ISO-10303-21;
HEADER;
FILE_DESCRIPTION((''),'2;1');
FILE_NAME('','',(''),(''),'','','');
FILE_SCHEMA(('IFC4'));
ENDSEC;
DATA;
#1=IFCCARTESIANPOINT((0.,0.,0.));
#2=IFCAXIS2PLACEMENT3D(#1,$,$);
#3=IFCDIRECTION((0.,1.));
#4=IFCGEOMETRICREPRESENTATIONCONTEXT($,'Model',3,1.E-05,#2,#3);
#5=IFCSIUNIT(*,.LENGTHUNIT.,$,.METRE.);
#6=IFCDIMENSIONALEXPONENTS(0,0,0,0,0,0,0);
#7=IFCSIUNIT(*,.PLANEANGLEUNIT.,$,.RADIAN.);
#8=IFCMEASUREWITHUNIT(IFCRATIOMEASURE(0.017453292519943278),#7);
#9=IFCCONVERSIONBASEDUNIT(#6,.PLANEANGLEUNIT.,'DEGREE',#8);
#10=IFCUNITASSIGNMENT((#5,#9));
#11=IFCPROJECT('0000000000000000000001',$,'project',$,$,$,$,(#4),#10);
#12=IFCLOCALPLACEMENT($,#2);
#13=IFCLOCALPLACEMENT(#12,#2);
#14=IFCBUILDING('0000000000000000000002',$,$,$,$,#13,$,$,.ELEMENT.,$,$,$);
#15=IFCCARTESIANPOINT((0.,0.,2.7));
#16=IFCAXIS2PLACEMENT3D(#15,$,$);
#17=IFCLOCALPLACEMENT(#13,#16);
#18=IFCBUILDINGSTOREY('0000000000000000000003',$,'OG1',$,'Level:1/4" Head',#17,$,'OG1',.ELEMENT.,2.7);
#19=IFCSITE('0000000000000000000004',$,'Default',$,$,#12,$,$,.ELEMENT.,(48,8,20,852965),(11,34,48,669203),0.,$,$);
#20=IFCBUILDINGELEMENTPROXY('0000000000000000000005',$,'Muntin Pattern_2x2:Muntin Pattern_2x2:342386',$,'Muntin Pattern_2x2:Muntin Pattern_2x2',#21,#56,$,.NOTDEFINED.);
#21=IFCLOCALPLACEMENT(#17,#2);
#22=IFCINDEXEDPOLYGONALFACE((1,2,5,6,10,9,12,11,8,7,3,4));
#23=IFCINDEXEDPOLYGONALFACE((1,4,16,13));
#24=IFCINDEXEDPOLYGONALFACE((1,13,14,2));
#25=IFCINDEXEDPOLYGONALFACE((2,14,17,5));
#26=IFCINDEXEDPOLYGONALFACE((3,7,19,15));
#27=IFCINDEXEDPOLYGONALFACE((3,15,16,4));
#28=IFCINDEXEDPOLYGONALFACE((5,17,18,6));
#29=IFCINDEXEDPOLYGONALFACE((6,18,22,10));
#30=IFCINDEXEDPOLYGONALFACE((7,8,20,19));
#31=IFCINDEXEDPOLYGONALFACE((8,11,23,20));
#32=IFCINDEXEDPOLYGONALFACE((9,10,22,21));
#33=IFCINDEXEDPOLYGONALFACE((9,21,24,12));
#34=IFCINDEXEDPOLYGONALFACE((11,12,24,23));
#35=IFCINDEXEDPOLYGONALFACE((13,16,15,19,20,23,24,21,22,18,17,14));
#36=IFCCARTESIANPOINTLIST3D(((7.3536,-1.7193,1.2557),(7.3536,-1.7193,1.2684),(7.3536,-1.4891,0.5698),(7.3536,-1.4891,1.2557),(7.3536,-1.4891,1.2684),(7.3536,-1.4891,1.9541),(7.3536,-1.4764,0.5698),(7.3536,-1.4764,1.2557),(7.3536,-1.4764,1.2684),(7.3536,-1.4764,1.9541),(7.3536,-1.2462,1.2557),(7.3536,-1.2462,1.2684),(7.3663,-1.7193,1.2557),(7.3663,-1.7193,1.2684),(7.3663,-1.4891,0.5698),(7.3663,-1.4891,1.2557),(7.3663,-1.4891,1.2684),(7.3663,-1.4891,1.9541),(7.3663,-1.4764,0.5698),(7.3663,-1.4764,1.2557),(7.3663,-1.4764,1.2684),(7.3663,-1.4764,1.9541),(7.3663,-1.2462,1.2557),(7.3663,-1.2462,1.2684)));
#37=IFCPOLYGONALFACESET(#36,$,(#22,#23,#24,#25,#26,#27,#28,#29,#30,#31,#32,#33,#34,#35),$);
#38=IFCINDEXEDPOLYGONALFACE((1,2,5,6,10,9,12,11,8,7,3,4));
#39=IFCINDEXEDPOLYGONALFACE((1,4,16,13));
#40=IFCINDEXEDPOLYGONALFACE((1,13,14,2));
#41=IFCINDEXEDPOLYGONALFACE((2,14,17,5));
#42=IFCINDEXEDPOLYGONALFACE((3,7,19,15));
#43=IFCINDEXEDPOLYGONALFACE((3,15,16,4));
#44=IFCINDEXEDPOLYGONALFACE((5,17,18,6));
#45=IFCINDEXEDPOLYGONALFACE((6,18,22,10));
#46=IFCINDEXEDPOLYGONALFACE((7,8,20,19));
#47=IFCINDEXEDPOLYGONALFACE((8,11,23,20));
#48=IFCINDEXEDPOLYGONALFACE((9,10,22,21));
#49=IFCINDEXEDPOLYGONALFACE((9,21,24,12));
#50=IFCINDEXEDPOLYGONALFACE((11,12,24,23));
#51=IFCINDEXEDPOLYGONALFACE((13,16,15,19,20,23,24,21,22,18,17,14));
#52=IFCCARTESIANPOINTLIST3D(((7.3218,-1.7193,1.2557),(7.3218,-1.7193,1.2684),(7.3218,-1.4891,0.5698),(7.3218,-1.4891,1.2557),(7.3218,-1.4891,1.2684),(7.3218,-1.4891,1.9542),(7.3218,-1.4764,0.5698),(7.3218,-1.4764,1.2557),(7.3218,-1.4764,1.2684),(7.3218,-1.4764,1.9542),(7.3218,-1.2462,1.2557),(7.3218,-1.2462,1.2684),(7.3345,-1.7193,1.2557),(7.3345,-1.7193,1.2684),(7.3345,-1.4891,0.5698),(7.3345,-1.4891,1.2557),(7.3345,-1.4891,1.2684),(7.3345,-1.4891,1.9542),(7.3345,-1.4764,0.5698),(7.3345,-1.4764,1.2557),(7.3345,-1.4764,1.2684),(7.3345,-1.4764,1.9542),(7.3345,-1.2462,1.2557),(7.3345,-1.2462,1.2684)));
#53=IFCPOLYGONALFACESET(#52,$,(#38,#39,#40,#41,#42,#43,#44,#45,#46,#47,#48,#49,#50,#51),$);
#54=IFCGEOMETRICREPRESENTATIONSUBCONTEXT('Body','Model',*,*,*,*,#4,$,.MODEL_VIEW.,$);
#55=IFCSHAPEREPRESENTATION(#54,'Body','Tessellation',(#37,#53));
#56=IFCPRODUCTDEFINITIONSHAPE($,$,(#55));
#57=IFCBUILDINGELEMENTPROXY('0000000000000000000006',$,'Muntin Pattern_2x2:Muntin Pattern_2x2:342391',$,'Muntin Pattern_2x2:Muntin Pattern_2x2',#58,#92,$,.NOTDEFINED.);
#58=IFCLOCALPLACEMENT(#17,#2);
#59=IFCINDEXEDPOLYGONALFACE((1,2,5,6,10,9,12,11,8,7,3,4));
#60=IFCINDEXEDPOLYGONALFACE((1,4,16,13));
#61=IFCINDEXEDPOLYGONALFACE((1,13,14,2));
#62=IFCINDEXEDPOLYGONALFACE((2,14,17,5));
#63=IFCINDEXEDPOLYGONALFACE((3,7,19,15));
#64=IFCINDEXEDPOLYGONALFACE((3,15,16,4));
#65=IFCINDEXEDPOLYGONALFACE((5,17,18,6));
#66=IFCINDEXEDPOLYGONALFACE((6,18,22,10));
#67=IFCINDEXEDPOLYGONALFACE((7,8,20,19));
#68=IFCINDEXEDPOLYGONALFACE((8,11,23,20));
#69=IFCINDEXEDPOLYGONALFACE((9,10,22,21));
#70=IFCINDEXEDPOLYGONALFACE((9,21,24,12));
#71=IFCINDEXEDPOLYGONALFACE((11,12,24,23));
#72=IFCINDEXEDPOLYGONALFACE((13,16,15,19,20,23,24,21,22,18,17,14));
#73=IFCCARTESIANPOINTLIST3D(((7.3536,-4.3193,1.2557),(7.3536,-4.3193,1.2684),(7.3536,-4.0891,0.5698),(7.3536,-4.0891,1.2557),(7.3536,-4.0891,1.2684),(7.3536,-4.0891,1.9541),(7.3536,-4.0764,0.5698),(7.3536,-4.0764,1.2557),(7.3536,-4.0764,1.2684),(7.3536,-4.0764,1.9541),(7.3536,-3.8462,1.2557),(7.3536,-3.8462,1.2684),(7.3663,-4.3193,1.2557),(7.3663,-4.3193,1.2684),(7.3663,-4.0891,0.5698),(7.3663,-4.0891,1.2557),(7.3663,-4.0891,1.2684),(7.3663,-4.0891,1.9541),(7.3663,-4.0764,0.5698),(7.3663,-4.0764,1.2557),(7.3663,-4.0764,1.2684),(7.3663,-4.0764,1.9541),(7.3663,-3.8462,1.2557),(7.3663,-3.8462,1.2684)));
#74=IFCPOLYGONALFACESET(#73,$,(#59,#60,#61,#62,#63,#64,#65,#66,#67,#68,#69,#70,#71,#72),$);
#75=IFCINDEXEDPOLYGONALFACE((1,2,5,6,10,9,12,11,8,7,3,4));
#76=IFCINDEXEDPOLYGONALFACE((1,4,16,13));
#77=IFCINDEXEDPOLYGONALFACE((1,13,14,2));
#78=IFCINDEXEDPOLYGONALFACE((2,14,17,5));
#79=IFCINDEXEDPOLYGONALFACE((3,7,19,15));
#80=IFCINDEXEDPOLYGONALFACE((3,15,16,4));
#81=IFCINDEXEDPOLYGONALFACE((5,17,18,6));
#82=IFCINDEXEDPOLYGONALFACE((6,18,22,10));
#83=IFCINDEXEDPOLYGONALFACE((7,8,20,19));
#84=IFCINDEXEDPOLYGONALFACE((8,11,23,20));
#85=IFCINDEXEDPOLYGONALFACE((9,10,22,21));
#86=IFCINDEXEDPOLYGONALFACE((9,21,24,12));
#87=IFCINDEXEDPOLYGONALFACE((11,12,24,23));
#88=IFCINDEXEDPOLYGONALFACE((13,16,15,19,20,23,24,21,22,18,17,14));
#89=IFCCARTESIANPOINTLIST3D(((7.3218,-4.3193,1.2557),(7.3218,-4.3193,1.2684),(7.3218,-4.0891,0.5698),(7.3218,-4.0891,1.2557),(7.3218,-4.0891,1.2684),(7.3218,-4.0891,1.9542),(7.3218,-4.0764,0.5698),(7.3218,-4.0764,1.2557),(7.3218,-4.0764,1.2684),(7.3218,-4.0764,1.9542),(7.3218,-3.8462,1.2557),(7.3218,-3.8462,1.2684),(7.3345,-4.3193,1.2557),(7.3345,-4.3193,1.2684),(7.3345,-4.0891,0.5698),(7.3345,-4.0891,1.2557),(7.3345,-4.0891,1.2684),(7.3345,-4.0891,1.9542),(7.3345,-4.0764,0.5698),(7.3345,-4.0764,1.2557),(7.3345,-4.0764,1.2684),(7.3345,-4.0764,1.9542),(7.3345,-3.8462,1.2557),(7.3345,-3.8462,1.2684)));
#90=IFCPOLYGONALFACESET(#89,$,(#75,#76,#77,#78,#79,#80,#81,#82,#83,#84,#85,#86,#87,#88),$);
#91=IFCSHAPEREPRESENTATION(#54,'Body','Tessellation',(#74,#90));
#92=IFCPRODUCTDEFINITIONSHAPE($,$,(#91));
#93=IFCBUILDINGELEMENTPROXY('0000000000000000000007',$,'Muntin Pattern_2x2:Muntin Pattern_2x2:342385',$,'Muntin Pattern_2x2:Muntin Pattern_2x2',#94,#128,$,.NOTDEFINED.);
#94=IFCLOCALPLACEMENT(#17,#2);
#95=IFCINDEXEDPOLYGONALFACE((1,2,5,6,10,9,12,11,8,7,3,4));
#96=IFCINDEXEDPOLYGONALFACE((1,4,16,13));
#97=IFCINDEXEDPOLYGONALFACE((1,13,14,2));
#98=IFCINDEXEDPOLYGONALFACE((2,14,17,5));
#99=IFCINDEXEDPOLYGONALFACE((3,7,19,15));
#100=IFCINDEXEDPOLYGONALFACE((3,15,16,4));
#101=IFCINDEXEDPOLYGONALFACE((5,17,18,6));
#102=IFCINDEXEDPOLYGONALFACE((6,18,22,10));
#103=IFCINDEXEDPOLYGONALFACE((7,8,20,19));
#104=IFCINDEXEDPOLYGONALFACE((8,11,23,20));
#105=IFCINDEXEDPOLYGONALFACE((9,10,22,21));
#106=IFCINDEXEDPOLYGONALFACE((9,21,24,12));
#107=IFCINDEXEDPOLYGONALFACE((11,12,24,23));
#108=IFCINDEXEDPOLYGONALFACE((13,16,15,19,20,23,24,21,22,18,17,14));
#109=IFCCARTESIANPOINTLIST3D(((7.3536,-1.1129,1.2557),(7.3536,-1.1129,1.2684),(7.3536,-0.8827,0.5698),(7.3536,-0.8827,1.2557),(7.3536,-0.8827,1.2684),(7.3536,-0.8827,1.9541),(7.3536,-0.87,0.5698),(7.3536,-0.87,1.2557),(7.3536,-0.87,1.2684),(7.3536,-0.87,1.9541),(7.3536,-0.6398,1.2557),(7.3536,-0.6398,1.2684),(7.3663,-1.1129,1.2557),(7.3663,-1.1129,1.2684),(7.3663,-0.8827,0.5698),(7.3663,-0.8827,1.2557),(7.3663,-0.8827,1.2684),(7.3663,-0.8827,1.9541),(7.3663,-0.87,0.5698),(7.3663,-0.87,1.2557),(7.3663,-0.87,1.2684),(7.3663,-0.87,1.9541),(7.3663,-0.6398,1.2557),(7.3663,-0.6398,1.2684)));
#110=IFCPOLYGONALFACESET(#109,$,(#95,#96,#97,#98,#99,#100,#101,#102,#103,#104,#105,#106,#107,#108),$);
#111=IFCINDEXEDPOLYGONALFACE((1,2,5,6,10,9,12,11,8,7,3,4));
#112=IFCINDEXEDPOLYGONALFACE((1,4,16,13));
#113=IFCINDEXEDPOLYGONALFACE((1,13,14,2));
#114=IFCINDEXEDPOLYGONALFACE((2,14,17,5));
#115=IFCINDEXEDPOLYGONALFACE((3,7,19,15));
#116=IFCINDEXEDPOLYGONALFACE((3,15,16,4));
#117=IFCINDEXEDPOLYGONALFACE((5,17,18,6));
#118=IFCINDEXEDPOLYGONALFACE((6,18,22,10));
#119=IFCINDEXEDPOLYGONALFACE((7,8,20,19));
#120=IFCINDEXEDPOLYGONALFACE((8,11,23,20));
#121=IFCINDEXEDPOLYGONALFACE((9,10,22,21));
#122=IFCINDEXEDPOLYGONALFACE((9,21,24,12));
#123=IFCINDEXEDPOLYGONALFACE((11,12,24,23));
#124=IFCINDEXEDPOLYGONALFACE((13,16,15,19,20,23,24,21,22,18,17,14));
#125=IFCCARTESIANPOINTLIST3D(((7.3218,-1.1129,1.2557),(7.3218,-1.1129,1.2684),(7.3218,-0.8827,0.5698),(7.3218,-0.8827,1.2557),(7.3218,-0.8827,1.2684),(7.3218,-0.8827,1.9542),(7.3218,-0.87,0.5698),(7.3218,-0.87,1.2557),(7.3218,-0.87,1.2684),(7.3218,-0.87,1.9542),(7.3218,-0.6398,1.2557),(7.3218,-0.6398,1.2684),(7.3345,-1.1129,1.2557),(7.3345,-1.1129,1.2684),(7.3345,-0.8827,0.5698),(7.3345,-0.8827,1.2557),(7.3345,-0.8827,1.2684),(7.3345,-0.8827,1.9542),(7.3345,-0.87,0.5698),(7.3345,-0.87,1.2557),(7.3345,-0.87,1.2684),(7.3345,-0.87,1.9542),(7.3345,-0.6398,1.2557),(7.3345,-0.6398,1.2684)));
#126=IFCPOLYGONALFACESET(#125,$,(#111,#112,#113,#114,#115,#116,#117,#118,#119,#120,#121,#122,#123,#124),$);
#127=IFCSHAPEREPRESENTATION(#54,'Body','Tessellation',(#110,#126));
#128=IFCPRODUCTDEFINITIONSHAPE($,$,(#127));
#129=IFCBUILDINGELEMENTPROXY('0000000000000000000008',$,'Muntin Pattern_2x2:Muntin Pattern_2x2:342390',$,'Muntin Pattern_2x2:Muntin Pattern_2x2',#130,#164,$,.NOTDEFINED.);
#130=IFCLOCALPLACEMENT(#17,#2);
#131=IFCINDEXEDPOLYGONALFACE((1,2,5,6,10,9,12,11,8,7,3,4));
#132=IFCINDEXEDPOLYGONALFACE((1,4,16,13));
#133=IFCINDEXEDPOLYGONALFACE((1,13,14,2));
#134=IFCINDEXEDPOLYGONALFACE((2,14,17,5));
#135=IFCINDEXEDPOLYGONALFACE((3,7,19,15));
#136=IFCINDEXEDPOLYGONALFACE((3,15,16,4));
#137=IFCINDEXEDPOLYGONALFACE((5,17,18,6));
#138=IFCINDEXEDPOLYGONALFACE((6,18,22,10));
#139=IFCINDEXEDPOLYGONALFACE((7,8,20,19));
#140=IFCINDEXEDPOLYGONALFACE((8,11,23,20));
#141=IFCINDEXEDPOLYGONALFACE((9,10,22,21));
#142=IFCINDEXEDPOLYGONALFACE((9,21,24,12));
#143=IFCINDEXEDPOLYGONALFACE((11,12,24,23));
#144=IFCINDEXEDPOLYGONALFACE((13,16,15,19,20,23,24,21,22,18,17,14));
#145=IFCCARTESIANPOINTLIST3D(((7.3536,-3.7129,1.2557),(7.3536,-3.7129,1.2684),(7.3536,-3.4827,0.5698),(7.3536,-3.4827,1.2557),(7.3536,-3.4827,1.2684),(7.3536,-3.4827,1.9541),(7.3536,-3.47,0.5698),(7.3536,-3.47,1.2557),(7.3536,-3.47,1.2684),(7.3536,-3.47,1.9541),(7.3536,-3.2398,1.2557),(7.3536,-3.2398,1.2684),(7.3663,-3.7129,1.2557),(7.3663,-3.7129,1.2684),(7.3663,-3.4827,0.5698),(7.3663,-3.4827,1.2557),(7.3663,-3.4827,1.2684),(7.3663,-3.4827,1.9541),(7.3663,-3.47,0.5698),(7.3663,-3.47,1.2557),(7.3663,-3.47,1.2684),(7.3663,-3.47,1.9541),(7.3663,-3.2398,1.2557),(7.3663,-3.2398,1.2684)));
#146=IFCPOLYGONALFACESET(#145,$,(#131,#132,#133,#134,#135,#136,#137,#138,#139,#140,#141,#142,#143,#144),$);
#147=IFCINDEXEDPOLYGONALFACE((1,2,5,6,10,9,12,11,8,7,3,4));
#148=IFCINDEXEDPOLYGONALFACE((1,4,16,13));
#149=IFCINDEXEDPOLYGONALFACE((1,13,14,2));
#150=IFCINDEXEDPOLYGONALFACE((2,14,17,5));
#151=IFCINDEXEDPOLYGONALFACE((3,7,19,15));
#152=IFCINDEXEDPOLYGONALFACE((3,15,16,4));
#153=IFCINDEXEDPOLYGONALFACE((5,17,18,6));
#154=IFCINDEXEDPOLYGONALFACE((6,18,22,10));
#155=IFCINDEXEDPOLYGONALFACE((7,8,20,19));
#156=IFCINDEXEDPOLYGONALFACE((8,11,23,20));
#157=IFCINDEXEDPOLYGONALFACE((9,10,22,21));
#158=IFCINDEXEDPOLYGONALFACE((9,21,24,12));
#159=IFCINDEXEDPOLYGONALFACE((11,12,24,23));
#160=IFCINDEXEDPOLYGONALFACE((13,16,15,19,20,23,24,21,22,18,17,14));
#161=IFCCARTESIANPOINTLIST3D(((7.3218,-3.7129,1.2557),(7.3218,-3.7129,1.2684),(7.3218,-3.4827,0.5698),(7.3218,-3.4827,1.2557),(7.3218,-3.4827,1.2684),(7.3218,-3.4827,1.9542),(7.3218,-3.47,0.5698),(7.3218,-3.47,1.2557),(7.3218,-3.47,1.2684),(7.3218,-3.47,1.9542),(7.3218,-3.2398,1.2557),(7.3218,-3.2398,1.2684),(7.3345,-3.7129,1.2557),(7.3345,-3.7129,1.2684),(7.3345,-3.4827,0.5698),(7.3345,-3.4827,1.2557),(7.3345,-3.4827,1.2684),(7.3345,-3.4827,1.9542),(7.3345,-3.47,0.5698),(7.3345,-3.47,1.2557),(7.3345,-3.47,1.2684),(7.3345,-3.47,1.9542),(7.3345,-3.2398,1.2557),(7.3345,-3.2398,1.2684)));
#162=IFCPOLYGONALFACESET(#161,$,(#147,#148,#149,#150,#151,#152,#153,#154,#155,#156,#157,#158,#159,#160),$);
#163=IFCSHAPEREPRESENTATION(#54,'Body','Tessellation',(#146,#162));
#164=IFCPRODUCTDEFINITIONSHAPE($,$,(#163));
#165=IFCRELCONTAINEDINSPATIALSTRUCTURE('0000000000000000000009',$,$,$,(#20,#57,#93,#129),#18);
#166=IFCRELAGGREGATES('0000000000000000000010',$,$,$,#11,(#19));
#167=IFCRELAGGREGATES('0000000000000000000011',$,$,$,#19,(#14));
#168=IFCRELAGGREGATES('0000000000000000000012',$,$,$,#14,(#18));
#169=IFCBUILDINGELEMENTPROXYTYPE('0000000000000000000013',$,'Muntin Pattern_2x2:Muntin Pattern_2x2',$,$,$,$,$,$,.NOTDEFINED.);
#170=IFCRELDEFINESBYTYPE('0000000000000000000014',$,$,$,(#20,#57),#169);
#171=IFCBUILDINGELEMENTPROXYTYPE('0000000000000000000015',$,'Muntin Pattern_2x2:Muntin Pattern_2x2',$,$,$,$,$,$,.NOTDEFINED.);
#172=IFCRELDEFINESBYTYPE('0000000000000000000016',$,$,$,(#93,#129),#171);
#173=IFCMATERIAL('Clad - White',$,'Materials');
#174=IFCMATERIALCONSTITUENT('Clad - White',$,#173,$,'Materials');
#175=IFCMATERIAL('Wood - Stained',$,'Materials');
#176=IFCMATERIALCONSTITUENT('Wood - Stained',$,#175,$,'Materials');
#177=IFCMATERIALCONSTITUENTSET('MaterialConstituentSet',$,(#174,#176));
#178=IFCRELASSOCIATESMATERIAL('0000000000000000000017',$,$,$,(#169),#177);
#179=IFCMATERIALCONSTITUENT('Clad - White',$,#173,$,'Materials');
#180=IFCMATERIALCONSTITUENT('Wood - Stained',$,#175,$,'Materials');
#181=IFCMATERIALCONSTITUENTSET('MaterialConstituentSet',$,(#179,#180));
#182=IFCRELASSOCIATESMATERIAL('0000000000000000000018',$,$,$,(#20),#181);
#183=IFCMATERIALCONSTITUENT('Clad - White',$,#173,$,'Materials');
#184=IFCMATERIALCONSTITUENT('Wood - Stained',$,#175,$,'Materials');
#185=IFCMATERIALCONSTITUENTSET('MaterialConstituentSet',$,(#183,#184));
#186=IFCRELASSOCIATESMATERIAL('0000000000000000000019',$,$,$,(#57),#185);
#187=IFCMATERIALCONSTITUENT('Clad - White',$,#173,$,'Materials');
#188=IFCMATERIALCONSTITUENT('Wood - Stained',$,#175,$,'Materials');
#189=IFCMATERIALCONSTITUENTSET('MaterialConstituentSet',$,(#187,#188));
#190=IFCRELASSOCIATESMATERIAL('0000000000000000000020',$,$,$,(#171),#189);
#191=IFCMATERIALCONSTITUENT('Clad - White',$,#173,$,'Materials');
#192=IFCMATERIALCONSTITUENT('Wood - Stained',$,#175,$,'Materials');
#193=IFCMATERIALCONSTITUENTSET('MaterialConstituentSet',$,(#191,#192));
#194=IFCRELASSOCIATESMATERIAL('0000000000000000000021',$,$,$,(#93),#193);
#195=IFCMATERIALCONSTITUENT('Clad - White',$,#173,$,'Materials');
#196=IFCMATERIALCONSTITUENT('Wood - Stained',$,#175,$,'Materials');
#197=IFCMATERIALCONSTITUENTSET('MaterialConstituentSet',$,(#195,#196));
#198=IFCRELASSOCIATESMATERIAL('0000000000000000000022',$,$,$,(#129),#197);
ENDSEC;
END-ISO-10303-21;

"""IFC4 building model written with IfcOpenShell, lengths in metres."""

from ifc_helpers import new_model, entity, si_unit, converted_unit, direction, frame, origin, place, context, subcontext, project, spatial, indexed_curve, outline, extrude, source, transform, mapped, material, constituent, constituent_set, type_object, type_shapes, element, save


model = new_model("IFC4")

# Units and contexts
model_context = context("Model", 3, precision=1e-05, world=origin(), true_north=direction((0.0, 1.0)))
body_context = subcontext(model_context, "Body", "Model", "MODEL_VIEW")
ifc_project = project(units=[si_unit("LENGTHUNIT", "METRE"), converted_unit("PLANEANGLEUNIT", "DEGREE", entity("IfcRatioMeasure", 0.017453292519943278), si_unit("PLANEANGLEUNIT", "RADIAN"), dimensions=[0, 0, 0, 0, 0, 0, 0])], contexts=[model_context])

# Site, building, storey
site_placement = place(None, origin())
site = spatial("IfcSite", under=ifc_project, at=site_placement, Name="Default", CompositionType="ELEMENT", RefLatitude=(48, 8, 20, 852965), RefLongitude=(11, 34, 48, 669203), RefElevation=0.0)
building_placement = place(site_placement, origin())
building = spatial("IfcBuilding", under=site, at=building_placement, CompositionType="ELEMENT")
storey_placement = place(building_placement, frame((0.0, 0.0, 2.7)))
storey = spatial("IfcBuildingStorey", under=building, at=storey_placement, Name="OG1", ObjectType="Level:1/4\" Head", LongName="OG1", CompositionType="ELEMENT", Elevation=2.7)

# Building element proxies
ifc_material_1 = material(Name="Clad - White", Category="Materials")
ifc_constituent_1 = constituent(ifc_material_1, Name="Clad - White", Category="Materials")
ifc_material_2 = material(Name="Wood - Stained", Category="Materials")
ifc_constituent_2 = constituent(ifc_material_2, Name="Wood - Stained", Category="Materials")
ifc_constituent_set_1 = constituent_set(constituents=[ifc_constituent_1, ifc_constituent_2], Name="MaterialConstituentSet")
ifc_constituent_3 = constituent(ifc_material_1, Name="Clad - White", Category="Materials")
ifc_constituent_4 = constituent(ifc_material_2, Name="Wood - Stained", Category="Materials")
ifc_constituent_set_2 = constituent_set(constituents=[ifc_constituent_3, ifc_constituent_4], Name="MaterialConstituentSet")
building_element_proxy_type_1 = type_object("IfcBuildingElementProxyType", Name="Muntin Pattern_2x2:Muntin Pattern_2x2", PredefinedType="NOTDEFINED", material=ifc_constituent_set_2)
shared_shape_1 = source(origin(), body_context, "Body", "SweptSolid", [
    extrude(outline(indexed_curve([(0.0064, -0.0064), (0.6921, -0.0064), (0.6921, 0.0063), (0.0064, 0.0063), (0.0064, 0.2365), (-0.0063, 0.2365), (-0.0063, 0.0063), (-0.6922, 0.0063), (-0.6922, -0.0064), (-0.0063, -0.0064), (-0.0063, -0.2365), (0.0064, -0.2365), (0.0064, -0.0064)], self_intersect=False)), frame((0.0, -0.0222, 0.6921), z_axis=(0.0, 1.0, 0.0), x_axis=(0.0, 0.0, 1.0)), (0.0, 0.0, 1.0), 0.0127),
    extrude(outline(indexed_curve([(0.0064, -0.0064), (0.6922, -0.0064), (0.6922, 0.0063), (0.0064, 0.0063), (0.0064, 0.2365), (-0.0063, 0.2365), (-0.0063, 0.0063), (-0.6922, 0.0063), (-0.6922, -0.0064), (-0.0063, -0.0064), (-0.0063, -0.2365), (0.0064, -0.2365), (0.0064, -0.0064)], self_intersect=False)), frame((0.0, 0.0095, 0.6922), z_axis=(0.0, 1.0, 0.0), x_axis=(0.0, 0.0, 1.0)), (0.0, 0.0, 1.0), 0.0127),
])
type_shapes(building_element_proxy_type_1, [shared_shape_1])
proxy_1_placement = place(storey_placement, frame((7.3441, -1.4828, 0.5699), z_axis=(0.0, 0.0, 1.0), x_axis=(0.0, 1.0, 0.0)))
element("IfcBuildingElementProxy", 1, at=proxy_1_placement, inside=storey, type_object=building_element_proxy_type_1, material=ifc_constituent_set_1, Name="Muntin Pattern_2x2:Muntin Pattern_2x2:342386", ObjectType="Muntin Pattern_2x2:Muntin Pattern_2x2", PredefinedType="NOTDEFINED", context=body_context, shape_type="MappedRepresentation", body=[
    mapped(shared_shape_1, transform((0.0, 0.0, 0.0), scale=1.0)),
])
ifc_constituent_5 = constituent(ifc_material_1, Name="Clad - White", Category="Materials")
ifc_constituent_6 = constituent(ifc_material_2, Name="Wood - Stained", Category="Materials")
ifc_constituent_set_3 = constituent_set(constituents=[ifc_constituent_5, ifc_constituent_6], Name="MaterialConstituentSet")
proxy_2_placement = place(storey_placement, frame((7.3441, -4.0828, 0.5699), z_axis=(0.0, 0.0, 1.0), x_axis=(0.0, 1.0, 0.0)))
element("IfcBuildingElementProxy", 2, at=proxy_2_placement, inside=storey, type_object=building_element_proxy_type_1, material=ifc_constituent_set_3, Name="Muntin Pattern_2x2:Muntin Pattern_2x2:342391", ObjectType="Muntin Pattern_2x2:Muntin Pattern_2x2", PredefinedType="NOTDEFINED", context=body_context, shape_type="MappedRepresentation", body=[
    mapped(shared_shape_1, transform((0.0, 0.0, 0.0), scale=1.0)),
])
ifc_constituent_7 = constituent(ifc_material_1, Name="Clad - White", Category="Materials")
ifc_constituent_8 = constituent(ifc_material_2, Name="Wood - Stained", Category="Materials")
ifc_constituent_set_4 = constituent_set(constituents=[ifc_constituent_7, ifc_constituent_8], Name="MaterialConstituentSet")
ifc_constituent_9 = constituent(ifc_material_1, Name="Clad - White", Category="Materials")
ifc_constituent_10 = constituent(ifc_material_2, Name="Wood - Stained", Category="Materials")
ifc_constituent_set_5 = constituent_set(constituents=[ifc_constituent_9, ifc_constituent_10], Name="MaterialConstituentSet")
building_element_proxy_type_2 = type_object("IfcBuildingElementProxyType", Name="Muntin Pattern_2x2:Muntin Pattern_2x2", PredefinedType="NOTDEFINED", material=ifc_constituent_set_5)
shared_shape_2 = source(origin(), body_context, "Body", "SweptSolid", [
    extrude(outline(indexed_curve([(0.0064, -0.0064), (0.6921, -0.0064), (0.6921, 0.0063), (0.0064, 0.0063), (0.0064, 0.2365), (-0.0063, 0.2365), (-0.0063, 0.0063), (-0.6922, 0.0063), (-0.6922, -0.0064), (-0.0063, -0.0064), (-0.0063, -0.2365), (0.0064, -0.2365), (0.0064, -0.0064)], self_intersect=False)), frame((0.0, 0.0095, 0.6921), z_axis=(0.0, 1.0, 0.0), x_axis=(0.0, 0.0, 1.0)), (0.0, 0.0, 1.0), 0.0127),
    extrude(outline(indexed_curve([(0.0064, -0.0064), (0.6922, -0.0064), (0.6922, 0.0063), (0.0064, 0.0063), (0.0064, 0.2365), (-0.0063, 0.2365), (-0.0063, 0.0063), (-0.6922, 0.0063), (-0.6922, -0.0064), (-0.0063, -0.0064), (-0.0063, -0.2365), (0.0064, -0.2365), (0.0064, -0.0064)], self_intersect=False)), frame((0.0, -0.0222, 0.6922), z_axis=(0.0, 1.0, 0.0), x_axis=(0.0, 0.0, 1.0)), (0.0, 0.0, 1.0), 0.0127),
])
type_shapes(building_element_proxy_type_2, [shared_shape_2])
proxy_3_placement = place(storey_placement, frame((7.3441, -0.8763, 0.5699), z_axis=(0.0, 0.0, 1.0), x_axis=(0.0, -1.0, 0.0)))
element("IfcBuildingElementProxy", 3, at=proxy_3_placement, inside=storey, type_object=building_element_proxy_type_2, material=ifc_constituent_set_4, Name="Muntin Pattern_2x2:Muntin Pattern_2x2:342385", ObjectType="Muntin Pattern_2x2:Muntin Pattern_2x2", PredefinedType="NOTDEFINED", context=body_context, shape_type="MappedRepresentation", body=[
    mapped(shared_shape_2, transform((0.0, 0.0, 0.0), scale=1.0)),
])
ifc_constituent_11 = constituent(ifc_material_1, Name="Clad - White", Category="Materials")
ifc_constituent_12 = constituent(ifc_material_2, Name="Wood - Stained", Category="Materials")
ifc_constituent_set_6 = constituent_set(constituents=[ifc_constituent_11, ifc_constituent_12], Name="MaterialConstituentSet")
proxy_4_placement = place(storey_placement, frame((7.3441, -3.4763, 0.5699), z_axis=(0.0, 0.0, 1.0), x_axis=(0.0, -1.0, 0.0)))
element("IfcBuildingElementProxy", 4, at=proxy_4_placement, inside=storey, type_object=building_element_proxy_type_2, material=ifc_constituent_set_6, Name="Muntin Pattern_2x2:Muntin Pattern_2x2:342390", ObjectType="Muntin Pattern_2x2:Muntin Pattern_2x2", PredefinedType="NOTDEFINED", context=body_context, shape_type="MappedRepresentation", body=[
    mapped(shared_shape_2, transform((0.0, 0.0, 0.0), scale=1.0)),
])

save(model, "model.ifc")
